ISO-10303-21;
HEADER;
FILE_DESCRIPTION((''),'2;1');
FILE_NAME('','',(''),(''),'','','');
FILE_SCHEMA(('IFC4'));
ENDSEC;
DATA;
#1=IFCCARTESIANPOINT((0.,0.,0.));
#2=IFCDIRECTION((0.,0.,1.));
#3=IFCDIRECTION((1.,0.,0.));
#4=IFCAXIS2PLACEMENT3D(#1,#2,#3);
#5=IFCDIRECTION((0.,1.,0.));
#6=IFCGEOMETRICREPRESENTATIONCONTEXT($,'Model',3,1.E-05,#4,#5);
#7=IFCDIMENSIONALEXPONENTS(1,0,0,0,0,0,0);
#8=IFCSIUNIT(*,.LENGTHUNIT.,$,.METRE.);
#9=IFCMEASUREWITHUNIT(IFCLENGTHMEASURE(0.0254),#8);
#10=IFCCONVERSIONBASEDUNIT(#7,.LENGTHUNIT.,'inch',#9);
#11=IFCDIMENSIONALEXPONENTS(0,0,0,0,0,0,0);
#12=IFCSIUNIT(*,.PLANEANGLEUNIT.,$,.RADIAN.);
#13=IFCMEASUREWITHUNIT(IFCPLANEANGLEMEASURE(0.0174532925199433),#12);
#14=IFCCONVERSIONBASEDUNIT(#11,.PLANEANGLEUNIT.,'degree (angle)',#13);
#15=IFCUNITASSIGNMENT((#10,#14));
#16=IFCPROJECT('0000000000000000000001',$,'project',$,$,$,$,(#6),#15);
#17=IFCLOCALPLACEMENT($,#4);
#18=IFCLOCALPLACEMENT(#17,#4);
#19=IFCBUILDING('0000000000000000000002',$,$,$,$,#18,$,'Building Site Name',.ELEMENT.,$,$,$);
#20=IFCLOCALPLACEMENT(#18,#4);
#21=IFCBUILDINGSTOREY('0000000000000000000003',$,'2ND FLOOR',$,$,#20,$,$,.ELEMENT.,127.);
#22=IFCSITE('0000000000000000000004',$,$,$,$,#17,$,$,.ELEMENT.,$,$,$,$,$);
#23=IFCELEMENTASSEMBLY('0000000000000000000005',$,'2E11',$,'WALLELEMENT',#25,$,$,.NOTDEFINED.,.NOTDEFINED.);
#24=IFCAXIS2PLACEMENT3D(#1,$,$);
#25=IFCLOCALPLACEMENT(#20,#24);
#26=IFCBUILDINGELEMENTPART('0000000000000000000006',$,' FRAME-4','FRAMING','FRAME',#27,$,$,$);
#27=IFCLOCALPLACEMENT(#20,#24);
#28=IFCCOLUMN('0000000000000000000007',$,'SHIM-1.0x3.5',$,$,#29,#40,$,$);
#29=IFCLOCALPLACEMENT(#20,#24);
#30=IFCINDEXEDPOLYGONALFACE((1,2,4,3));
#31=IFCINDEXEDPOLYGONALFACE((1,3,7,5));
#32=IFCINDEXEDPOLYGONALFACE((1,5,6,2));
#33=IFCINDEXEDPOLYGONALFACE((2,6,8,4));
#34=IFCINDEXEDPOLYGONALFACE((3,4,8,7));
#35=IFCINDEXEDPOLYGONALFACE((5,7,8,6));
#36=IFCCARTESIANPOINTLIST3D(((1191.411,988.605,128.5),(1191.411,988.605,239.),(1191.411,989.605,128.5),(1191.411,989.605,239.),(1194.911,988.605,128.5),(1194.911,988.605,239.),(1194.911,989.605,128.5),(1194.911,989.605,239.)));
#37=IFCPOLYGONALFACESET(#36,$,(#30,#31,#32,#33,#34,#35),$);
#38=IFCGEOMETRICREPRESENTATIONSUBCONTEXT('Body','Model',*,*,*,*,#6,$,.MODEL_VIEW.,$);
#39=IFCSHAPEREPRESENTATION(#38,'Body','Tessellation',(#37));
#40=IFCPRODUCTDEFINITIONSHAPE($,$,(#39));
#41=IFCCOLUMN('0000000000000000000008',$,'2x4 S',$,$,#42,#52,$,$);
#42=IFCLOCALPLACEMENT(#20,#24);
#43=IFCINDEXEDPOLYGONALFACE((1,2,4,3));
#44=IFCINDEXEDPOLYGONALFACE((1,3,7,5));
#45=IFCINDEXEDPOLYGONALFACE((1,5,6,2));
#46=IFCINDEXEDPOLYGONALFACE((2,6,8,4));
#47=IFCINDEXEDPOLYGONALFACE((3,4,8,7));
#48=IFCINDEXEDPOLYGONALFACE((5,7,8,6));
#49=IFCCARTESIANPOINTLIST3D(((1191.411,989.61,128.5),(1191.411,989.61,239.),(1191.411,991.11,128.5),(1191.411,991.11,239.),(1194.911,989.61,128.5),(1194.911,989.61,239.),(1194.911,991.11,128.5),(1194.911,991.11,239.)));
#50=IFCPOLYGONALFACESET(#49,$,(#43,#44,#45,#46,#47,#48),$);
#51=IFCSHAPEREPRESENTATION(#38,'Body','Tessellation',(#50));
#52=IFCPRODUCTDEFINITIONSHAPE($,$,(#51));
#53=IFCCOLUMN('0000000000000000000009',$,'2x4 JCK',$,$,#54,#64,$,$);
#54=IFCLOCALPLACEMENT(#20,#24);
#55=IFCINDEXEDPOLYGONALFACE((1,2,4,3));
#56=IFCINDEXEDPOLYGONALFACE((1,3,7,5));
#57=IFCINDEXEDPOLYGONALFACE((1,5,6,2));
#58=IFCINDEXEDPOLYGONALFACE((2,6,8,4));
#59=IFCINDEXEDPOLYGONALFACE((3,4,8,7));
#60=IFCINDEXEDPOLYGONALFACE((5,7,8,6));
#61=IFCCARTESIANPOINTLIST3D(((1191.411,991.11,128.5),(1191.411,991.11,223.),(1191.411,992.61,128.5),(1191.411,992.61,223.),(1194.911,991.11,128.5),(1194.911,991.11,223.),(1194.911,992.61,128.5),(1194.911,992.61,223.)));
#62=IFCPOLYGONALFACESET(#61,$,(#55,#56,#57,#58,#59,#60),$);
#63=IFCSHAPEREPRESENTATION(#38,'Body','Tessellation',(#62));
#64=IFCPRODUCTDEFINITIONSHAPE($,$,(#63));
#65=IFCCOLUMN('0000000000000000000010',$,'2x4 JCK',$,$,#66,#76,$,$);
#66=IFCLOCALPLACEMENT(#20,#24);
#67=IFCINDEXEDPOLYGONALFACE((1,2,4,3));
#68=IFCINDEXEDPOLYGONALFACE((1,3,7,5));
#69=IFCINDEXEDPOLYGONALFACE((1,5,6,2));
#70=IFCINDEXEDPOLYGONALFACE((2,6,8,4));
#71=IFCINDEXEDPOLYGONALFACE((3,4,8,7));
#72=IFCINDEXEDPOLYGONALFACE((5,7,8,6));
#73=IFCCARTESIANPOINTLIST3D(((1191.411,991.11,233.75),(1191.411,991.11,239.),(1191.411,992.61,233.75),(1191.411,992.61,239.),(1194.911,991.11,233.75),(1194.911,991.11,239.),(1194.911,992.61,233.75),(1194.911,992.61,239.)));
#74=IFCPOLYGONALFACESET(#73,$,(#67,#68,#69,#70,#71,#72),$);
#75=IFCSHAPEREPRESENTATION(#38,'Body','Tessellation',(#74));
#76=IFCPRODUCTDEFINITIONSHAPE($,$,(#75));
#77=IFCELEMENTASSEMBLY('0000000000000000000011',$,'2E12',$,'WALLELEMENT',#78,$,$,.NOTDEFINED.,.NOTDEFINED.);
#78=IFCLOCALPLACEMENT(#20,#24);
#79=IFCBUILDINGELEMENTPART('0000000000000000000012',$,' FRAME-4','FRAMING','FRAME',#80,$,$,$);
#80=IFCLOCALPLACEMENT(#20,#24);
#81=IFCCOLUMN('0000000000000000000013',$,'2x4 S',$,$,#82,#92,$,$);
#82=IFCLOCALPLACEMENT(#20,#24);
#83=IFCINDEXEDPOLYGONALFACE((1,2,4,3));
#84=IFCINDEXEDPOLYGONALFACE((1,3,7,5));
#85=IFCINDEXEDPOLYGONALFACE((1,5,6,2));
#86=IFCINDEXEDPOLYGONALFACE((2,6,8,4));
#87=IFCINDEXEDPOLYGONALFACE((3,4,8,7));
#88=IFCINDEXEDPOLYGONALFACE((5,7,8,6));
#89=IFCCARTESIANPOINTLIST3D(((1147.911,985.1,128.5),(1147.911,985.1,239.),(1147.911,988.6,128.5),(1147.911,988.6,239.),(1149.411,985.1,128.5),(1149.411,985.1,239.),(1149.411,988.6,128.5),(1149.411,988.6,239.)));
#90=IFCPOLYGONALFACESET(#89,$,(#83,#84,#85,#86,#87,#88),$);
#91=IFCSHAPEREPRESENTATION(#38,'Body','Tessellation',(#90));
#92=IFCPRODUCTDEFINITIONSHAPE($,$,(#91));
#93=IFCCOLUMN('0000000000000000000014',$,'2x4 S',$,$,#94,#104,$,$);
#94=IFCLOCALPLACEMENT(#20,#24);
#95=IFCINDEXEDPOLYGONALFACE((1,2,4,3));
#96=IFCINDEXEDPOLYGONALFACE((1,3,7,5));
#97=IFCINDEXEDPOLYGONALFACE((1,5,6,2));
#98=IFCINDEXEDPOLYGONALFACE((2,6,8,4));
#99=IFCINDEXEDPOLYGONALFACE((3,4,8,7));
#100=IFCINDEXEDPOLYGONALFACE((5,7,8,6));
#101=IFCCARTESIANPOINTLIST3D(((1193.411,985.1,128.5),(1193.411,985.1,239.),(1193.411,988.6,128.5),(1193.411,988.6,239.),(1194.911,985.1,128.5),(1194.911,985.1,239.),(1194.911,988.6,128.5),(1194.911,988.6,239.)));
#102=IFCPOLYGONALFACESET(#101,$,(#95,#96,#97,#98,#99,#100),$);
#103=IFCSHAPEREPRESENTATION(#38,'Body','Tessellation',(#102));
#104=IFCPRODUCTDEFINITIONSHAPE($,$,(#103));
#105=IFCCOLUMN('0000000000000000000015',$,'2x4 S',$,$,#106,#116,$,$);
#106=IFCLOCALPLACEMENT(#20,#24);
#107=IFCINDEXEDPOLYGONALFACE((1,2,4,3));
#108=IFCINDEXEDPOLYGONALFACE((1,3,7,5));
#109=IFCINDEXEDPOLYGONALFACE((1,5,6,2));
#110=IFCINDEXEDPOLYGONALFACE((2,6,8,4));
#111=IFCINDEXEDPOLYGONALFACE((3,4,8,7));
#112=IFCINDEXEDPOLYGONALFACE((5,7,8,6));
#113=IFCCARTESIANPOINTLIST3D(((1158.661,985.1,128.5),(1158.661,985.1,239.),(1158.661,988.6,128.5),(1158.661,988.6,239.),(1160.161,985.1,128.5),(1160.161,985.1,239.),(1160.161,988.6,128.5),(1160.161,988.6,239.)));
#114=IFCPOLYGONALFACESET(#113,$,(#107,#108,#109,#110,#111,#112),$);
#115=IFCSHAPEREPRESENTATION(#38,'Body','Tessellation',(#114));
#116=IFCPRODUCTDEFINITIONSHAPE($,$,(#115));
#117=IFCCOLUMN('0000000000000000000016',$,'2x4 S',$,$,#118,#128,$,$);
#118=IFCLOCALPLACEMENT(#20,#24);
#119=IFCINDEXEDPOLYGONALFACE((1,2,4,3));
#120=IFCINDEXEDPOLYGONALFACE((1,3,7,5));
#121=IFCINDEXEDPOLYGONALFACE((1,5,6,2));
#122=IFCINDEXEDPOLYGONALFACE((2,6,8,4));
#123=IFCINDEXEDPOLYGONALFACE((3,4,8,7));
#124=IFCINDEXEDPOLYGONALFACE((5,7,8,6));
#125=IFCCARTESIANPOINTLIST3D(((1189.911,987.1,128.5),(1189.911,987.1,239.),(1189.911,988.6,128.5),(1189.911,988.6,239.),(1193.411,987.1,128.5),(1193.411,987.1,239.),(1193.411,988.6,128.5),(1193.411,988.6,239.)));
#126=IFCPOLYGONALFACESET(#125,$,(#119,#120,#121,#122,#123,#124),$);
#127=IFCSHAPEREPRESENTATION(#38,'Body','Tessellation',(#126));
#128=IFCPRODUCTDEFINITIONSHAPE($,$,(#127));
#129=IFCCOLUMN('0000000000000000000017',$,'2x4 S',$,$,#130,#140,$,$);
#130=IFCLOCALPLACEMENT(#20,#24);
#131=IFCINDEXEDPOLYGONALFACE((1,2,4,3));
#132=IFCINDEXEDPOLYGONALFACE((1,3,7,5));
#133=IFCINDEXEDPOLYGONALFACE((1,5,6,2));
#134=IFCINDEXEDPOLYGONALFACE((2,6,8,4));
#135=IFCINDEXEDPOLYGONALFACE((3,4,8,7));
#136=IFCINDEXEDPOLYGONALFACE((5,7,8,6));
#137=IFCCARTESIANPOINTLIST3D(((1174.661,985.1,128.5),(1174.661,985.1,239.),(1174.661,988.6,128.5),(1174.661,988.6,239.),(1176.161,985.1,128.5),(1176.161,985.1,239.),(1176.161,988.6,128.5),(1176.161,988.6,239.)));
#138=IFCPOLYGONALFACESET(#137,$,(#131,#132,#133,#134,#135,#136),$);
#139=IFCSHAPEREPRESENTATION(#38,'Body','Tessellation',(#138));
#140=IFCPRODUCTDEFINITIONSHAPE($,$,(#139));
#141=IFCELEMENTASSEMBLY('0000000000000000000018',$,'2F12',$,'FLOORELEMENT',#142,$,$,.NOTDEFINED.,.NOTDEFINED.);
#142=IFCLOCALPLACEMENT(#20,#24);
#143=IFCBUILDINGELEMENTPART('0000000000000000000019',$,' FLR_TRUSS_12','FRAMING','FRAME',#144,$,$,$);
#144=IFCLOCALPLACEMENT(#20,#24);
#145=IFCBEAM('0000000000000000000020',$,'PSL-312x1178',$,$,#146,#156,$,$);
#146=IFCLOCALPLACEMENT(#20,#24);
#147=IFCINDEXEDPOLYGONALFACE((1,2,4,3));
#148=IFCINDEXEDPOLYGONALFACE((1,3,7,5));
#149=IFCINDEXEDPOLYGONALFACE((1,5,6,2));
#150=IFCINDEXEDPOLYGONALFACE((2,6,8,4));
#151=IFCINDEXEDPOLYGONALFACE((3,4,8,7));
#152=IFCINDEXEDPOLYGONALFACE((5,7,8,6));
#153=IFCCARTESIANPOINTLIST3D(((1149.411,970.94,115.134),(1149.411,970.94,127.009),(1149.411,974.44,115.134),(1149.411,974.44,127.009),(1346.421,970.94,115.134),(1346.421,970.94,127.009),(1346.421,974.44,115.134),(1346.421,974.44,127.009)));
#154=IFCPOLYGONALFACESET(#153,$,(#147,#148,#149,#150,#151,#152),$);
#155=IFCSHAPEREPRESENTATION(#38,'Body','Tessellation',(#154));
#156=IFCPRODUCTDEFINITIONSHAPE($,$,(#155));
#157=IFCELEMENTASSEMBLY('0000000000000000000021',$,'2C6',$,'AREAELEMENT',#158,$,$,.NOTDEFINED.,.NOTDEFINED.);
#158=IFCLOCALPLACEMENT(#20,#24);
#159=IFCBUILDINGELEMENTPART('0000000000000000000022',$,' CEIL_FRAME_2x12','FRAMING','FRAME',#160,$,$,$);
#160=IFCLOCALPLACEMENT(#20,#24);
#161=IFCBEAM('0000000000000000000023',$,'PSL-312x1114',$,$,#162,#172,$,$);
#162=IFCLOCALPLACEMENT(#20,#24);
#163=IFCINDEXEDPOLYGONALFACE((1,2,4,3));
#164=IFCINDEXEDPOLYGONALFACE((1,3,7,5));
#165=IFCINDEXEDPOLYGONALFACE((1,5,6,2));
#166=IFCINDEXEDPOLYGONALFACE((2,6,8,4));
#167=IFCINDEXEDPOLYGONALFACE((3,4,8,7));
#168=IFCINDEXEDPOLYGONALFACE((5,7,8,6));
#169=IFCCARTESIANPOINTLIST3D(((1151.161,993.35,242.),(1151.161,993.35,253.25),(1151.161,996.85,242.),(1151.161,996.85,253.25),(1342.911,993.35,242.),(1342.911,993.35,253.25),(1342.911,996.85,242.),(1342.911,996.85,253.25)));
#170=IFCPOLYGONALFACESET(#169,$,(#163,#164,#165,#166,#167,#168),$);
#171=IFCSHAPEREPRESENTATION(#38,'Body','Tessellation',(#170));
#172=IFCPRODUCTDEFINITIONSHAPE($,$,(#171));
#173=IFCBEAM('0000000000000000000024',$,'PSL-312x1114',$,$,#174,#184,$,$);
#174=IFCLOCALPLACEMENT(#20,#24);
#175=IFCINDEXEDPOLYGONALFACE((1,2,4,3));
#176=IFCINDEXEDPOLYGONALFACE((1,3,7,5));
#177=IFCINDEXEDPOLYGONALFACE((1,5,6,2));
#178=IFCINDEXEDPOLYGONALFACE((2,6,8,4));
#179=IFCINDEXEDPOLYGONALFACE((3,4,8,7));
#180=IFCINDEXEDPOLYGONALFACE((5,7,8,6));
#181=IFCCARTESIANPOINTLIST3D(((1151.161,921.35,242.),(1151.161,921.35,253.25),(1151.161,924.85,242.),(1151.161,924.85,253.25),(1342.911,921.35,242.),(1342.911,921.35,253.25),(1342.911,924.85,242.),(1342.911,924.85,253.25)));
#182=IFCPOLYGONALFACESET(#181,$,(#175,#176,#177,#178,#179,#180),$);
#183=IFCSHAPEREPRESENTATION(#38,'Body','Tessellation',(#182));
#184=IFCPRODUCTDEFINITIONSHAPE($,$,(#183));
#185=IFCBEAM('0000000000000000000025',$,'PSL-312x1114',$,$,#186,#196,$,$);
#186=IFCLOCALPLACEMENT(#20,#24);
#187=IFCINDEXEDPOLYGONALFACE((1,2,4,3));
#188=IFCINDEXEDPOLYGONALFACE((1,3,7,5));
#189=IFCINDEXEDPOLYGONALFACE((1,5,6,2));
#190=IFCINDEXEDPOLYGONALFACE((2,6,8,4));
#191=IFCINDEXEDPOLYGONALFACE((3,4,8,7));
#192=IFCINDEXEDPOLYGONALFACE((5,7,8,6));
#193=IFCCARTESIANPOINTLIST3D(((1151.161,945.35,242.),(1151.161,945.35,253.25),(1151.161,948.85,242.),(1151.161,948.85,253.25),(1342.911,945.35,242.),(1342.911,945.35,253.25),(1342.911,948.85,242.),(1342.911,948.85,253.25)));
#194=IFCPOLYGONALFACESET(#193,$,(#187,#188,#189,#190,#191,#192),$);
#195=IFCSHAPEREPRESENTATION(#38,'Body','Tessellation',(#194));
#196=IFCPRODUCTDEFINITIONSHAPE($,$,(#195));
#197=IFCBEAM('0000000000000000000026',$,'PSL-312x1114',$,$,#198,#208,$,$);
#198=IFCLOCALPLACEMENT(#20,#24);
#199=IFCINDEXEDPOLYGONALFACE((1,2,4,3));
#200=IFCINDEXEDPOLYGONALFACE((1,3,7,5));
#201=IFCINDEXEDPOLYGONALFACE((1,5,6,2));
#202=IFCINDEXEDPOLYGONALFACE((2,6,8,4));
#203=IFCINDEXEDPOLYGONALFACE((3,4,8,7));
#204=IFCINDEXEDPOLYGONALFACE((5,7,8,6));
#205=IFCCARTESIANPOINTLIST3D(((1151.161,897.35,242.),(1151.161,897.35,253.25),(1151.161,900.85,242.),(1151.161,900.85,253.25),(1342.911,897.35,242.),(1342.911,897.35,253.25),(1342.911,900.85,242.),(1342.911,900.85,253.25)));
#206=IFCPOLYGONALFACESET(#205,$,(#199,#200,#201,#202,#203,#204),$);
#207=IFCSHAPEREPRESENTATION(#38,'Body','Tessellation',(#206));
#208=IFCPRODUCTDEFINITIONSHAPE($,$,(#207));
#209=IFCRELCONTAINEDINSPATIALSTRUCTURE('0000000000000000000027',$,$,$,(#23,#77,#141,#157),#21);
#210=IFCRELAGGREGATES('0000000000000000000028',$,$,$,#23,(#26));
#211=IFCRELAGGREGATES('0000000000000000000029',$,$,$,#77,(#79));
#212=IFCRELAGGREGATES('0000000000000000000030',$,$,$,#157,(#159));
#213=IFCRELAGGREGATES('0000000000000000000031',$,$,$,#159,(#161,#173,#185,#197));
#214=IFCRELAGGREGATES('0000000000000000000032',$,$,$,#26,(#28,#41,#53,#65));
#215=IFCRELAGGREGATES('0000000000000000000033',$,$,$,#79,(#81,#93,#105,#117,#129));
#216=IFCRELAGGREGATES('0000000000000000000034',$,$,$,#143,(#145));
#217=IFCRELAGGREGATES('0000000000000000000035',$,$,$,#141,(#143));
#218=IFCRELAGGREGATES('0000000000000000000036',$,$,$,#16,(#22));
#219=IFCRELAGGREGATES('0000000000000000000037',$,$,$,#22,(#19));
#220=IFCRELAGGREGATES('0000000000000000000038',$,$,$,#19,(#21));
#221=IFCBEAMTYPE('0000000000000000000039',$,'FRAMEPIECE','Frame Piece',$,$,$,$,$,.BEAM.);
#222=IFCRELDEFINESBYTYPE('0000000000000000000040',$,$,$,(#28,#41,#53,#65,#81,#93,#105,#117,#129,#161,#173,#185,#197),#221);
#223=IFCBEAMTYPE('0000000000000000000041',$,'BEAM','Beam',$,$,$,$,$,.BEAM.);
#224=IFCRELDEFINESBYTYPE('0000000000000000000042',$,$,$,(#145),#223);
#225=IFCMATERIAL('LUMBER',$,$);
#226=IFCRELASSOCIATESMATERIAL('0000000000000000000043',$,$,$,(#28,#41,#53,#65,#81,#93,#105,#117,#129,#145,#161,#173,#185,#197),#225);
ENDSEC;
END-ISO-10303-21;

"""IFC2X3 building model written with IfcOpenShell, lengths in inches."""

from ifc_helpers import new_model, entity, si_unit, converted_unit, direction, frame, frame_2d, origin_with_axes, place, context, subcontext, project, spatial, rectangle, extrude, material, type_object, element, aggregate, save


model = new_model("IFC2X3")

# Units and contexts
model_context = context("Model", 3, precision=1e-05, world=origin_with_axes(), true_north=direction((0.0, 1.0, 0.0)))
body_context = subcontext(model_context, "Body", "Model", "MODEL_VIEW")
ifc_project = project(units=[converted_unit("LENGTHUNIT", "inch", entity("IfcLengthMeasure", 0.0254), si_unit("LENGTHUNIT", "METRE"), dimensions=[1, 0, 0, 0, 0, 0, 0]), converted_unit("PLANEANGLEUNIT", "degree (angle)", entity("IfcPlaneAngleMeasure", 0.0174532925199433), si_unit("PLANEANGLEUNIT", "RADIAN"), dimensions=[0, 0, 0, 0, 0, 0, 0])], contexts=[model_context])

# Site, building, storey
site_placement = place(None, origin_with_axes())
site = spatial("IfcSite", under=ifc_project, at=site_placement, CompositionType="ELEMENT")
building_placement = place(site_placement, origin_with_axes())
building = spatial("IfcBuilding", under=site, at=building_placement, LongName="Building Site Name", CompositionType="ELEMENT")
storey_placement = place(building_placement, origin_with_axes())
storey = spatial("IfcBuildingStorey", under=building, at=storey_placement, Name="2ND FLOOR", CompositionType="ELEMENT", Elevation=127.0)

# Element assemblies, building element parts, columns
assembly_1_placement = place(storey_placement, origin_with_axes())
assembly_1 = element("IfcElementAssembly", 1, at=assembly_1_placement, inside=storey, Name="2E11", ObjectType="WALLELEMENT", AssemblyPlace="NOTDEFINED", PredefinedType="NOTDEFINED")
building_element_part_1 = element("IfcBuildingElementPart", 2, Name=" FRAME-4", Description="FRAMING", ObjectType="FRAME")
aggregate(assembly_1, [building_element_part_1])
ifc_material_1 = material(Name="LUMBER")
beam_type_1 = type_object("IfcBeamType", Name="FRAMEPIECE", Description="Frame Piece", PredefinedType="BEAM")
column_1_placement = place(assembly_1_placement, frame((1193.161, 989.105, 128.5), z_axis=(0.0, 0.0, 1.0), x_axis=(0.0, 1.0, 0.0)))
column_1 = element("IfcColumn", 3, at=column_1_placement, type_object=beam_type_1, material=ifc_material_1, Name="SHIM-1.0x3.5", context=body_context, shape_type="SweptSolid", body=[
    extrude(rectangle(XDim=1.0, YDim=3.5, at=frame_2d((0.0, 0.0), x_axis=(-1.0, 0.0))), origin_with_axes(), (0.0, 0.0, 1.0), 110.5),
])
column_2_placement = place(assembly_1_placement, frame((1193.161, 990.36, 128.5), z_axis=(0.0, 0.0, 1.0), x_axis=(0.0, 1.0, 0.0)))
column_2 = element("IfcColumn", 4, at=column_2_placement, type_object=beam_type_1, material=ifc_material_1, Name="2x4 S", context=body_context, shape_type="SweptSolid", body=[
    extrude(rectangle(XDim=1.5, YDim=3.5, at=frame_2d((0.0, 0.0), x_axis=(-1.0, 0.0))), origin_with_axes(), (0.0, 0.0, 1.0), 110.5),
])
column_3_placement = place(assembly_1_placement, frame((1193.161, 991.86, 128.5), z_axis=(0.0, 0.0, 1.0), x_axis=(0.0, 1.0, 0.0)))
column_3 = element("IfcColumn", 5, at=column_3_placement, type_object=beam_type_1, material=ifc_material_1, Name="2x4 JCK", context=body_context, shape_type="SweptSolid", body=[
    extrude(rectangle(XDim=1.5, YDim=3.5, at=frame_2d((0.0, 0.0), x_axis=(-1.0, 0.0))), origin_with_axes(), (0.0, 0.0, 1.0), 94.5),
])
column_4_placement = place(assembly_1_placement, frame((1193.161, 991.86, 233.75), z_axis=(0.0, 0.0, 1.0), x_axis=(0.0, 1.0, 0.0)))
column_4 = element("IfcColumn", 6, at=column_4_placement, type_object=beam_type_1, material=ifc_material_1, Name="2x4 JCK", context=body_context, shape_type="SweptSolid", body=[
    extrude(rectangle(XDim=1.5, YDim=3.5, at=frame_2d((0.0, 0.0), x_axis=(-1.0, 0.0))), origin_with_axes(), (0.0, 0.0, 1.0), 5.25),
])
assembly_2_placement = place(storey_placement, origin_with_axes())
assembly_2 = element("IfcElementAssembly", 7, at=assembly_2_placement, inside=storey, Name="2E12", ObjectType="WALLELEMENT", AssemblyPlace="NOTDEFINED", PredefinedType="NOTDEFINED")
building_element_part_2 = element("IfcBuildingElementPart", 8, Name=" FRAME-4", Description="FRAMING", ObjectType="FRAME")
aggregate(assembly_2, [building_element_part_2])
column_5_placement = place(assembly_2_placement, frame((1148.661, 986.85, 128.5), z_axis=(0.0, 0.0, 1.0), x_axis=(1.0, 0.0, 0.0)))
column_5 = element("IfcColumn", 9, at=column_5_placement, type_object=beam_type_1, material=ifc_material_1, Name="2x4 S", context=body_context, shape_type="SweptSolid", body=[
    extrude(rectangle(XDim=1.5, YDim=3.5, at=frame_2d((0.0, 0.0), x_axis=(-1.0, 0.0))), origin_with_axes(), (0.0, 0.0, 1.0), 110.5),
])
column_6_placement = place(assembly_2_placement, frame((1194.161, 986.85, 239.0), z_axis=(0.0, 0.0, -1.0), x_axis=(-1.0, 0.0, 0.0)))
column_6 = element("IfcColumn", 10, at=column_6_placement, type_object=beam_type_1, material=ifc_material_1, Name="2x4 S", context=body_context, shape_type="SweptSolid", body=[
    extrude(rectangle(XDim=1.5, YDim=3.5, at=frame_2d((0.0, 0.0), x_axis=(-1.0, 0.0))), origin_with_axes(), (0.0, 0.0, 1.0), 110.5),
])
column_7_placement = place(assembly_2_placement, frame((1159.411, 986.85, 239.0), z_axis=(0.0, 0.0, -1.0), x_axis=(-1.0, 0.0, 0.0)))
column_7 = element("IfcColumn", 11, at=column_7_placement, type_object=beam_type_1, material=ifc_material_1, Name="2x4 S", context=body_context, shape_type="SweptSolid", body=[
    extrude(rectangle(XDim=1.5, YDim=3.5, at=frame_2d((0.0, 0.0), x_axis=(-1.0, 0.0))), origin_with_axes(), (0.0, 0.0, 1.0), 110.5),
])
column_8_placement = place(assembly_2_placement, frame((1191.661, 987.85, 239.0), z_axis=(0.0, 0.0, -1.0), x_axis=(0.0, -1.0, 0.0)))
column_8 = element("IfcColumn", 12, at=column_8_placement, type_object=beam_type_1, material=ifc_material_1, Name="2x4 S", context=body_context, shape_type="SweptSolid", body=[
    extrude(rectangle(XDim=1.5, YDim=3.5, at=frame_2d((0.0, 0.0), x_axis=(-1.0, 0.0))), origin_with_axes(), (0.0, 0.0, 1.0), 110.5),
])
column_9_placement = place(assembly_2_placement, frame((1175.411, 986.85, 239.0), z_axis=(0.0, 0.0, -1.0), x_axis=(-1.0, 0.0, 0.0)))
column_9 = element("IfcColumn", 13, at=column_9_placement, type_object=beam_type_1, material=ifc_material_1, Name="2x4 S", context=body_context, shape_type="SweptSolid", body=[
    extrude(rectangle(XDim=1.5, YDim=3.5, at=frame_2d((0.0, 0.0), x_axis=(-1.0, 0.0))), origin_with_axes(), (0.0, 0.0, 1.0), 110.5),
])

# Element assembly, building element part, beam
assembly_3_placement = place(storey_placement, origin_with_axes())
assembly_3 = element("IfcElementAssembly", 14, at=assembly_3_placement, inside=storey, Name="2F12", ObjectType="FLOORELEMENT", AssemblyPlace="NOTDEFINED", PredefinedType="NOTDEFINED")
building_element_part_3 = element("IfcBuildingElementPart", 15, Name=" FLR_TRUSS_12", Description="FRAMING", ObjectType="FRAME")
beam_type_2 = type_object("IfcBeamType", Name="BEAM", Description="Beam", PredefinedType="BEAM")
beam_1_placement = place(assembly_3_placement, frame((1149.411, 972.69, 121.071), z_axis=(1.0, 0.0, 0.0), x_axis=(0.0, 1.0, 0.0)))
beam_1 = element("IfcBeam", 16, at=beam_1_placement, type_object=beam_type_2, material=ifc_material_1, Name="PSL-312x1178", context=body_context, shape_type="SweptSolid", body=[
    extrude(rectangle(XDim=3.5, YDim=11.875, at=frame_2d((0.0, 0.0), x_axis=(-1.0, 0.0))), origin_with_axes(), (0.0, 0.0, 1.0), 197.01),
])

# Element assembly, building element part, beams
assembly_4_placement = place(storey_placement, origin_with_axes())
assembly_4 = element("IfcElementAssembly", 17, at=assembly_4_placement, inside=storey, Name="2C6", ObjectType="AREAELEMENT", AssemblyPlace="NOTDEFINED", PredefinedType="NOTDEFINED")
building_element_part_4 = element("IfcBuildingElementPart", 18, Name=" CEIL_FRAME_2x12", Description="FRAMING", ObjectType="FRAME")
aggregate(assembly_4, [building_element_part_4])
beam_2_placement = place(assembly_4_placement, frame((1151.161, 995.1, 247.625), z_axis=(1.0, 0.0, 0.0), x_axis=(0.0, 1.0, 0.0)))
beam_2 = element("IfcBeam", 19, at=beam_2_placement, type_object=beam_type_1, material=ifc_material_1, Name="PSL-312x1114", context=body_context, shape_type="SweptSolid", body=[
    extrude(rectangle(XDim=3.5, YDim=11.25, at=frame_2d((0.0, 0.0), x_axis=(-1.0, 0.0))), origin_with_axes(), (0.0, 0.0, 1.0), 191.75),
])
beam_3_placement = place(assembly_4_placement, frame((1151.161, 923.1, 247.625), z_axis=(1.0, 0.0, 0.0), x_axis=(0.0, 1.0, 0.0)))
beam_3 = element("IfcBeam", 20, at=beam_3_placement, type_object=beam_type_1, material=ifc_material_1, Name="PSL-312x1114", context=body_context, shape_type="SweptSolid", body=[
    extrude(rectangle(XDim=3.5, YDim=11.25, at=frame_2d((0.0, 0.0), x_axis=(-1.0, 0.0))), origin_with_axes(), (0.0, 0.0, 1.0), 191.75),
])
beam_4_placement = place(assembly_4_placement, frame((1151.161, 947.1, 247.625), z_axis=(1.0, 0.0, 0.0), x_axis=(0.0, 1.0, 0.0)))
beam_4 = element("IfcBeam", 21, at=beam_4_placement, type_object=beam_type_1, material=ifc_material_1, Name="PSL-312x1114", context=body_context, shape_type="SweptSolid", body=[
    extrude(rectangle(XDim=3.5, YDim=11.25, at=frame_2d((0.0, 0.0), x_axis=(-1.0, 0.0))), origin_with_axes(), (0.0, 0.0, 1.0), 191.75),
])
beam_5_placement = place(assembly_4_placement, frame((1151.161, 899.1, 247.625), z_axis=(1.0, 0.0, 0.0), x_axis=(0.0, 1.0, 0.0)))
beam_5 = element("IfcBeam", 22, at=beam_5_placement, type_object=beam_type_1, material=ifc_material_1, Name="PSL-312x1114", context=body_context, shape_type="SweptSolid", body=[
    extrude(rectangle(XDim=3.5, YDim=11.25, at=frame_2d((0.0, 0.0), x_axis=(-1.0, 0.0))), origin_with_axes(), (0.0, 0.0, 1.0), 191.75),
])
aggregate(building_element_part_4, [beam_2, beam_3, beam_4, beam_5])

aggregate(building_element_part_1, [column_1, column_2, column_3, column_4])
aggregate(building_element_part_2, [column_5, column_6, column_7, column_8, column_9])
aggregate(building_element_part_3, [beam_1])

aggregate(assembly_3, [building_element_part_3])

save(model, "model.ifc")
